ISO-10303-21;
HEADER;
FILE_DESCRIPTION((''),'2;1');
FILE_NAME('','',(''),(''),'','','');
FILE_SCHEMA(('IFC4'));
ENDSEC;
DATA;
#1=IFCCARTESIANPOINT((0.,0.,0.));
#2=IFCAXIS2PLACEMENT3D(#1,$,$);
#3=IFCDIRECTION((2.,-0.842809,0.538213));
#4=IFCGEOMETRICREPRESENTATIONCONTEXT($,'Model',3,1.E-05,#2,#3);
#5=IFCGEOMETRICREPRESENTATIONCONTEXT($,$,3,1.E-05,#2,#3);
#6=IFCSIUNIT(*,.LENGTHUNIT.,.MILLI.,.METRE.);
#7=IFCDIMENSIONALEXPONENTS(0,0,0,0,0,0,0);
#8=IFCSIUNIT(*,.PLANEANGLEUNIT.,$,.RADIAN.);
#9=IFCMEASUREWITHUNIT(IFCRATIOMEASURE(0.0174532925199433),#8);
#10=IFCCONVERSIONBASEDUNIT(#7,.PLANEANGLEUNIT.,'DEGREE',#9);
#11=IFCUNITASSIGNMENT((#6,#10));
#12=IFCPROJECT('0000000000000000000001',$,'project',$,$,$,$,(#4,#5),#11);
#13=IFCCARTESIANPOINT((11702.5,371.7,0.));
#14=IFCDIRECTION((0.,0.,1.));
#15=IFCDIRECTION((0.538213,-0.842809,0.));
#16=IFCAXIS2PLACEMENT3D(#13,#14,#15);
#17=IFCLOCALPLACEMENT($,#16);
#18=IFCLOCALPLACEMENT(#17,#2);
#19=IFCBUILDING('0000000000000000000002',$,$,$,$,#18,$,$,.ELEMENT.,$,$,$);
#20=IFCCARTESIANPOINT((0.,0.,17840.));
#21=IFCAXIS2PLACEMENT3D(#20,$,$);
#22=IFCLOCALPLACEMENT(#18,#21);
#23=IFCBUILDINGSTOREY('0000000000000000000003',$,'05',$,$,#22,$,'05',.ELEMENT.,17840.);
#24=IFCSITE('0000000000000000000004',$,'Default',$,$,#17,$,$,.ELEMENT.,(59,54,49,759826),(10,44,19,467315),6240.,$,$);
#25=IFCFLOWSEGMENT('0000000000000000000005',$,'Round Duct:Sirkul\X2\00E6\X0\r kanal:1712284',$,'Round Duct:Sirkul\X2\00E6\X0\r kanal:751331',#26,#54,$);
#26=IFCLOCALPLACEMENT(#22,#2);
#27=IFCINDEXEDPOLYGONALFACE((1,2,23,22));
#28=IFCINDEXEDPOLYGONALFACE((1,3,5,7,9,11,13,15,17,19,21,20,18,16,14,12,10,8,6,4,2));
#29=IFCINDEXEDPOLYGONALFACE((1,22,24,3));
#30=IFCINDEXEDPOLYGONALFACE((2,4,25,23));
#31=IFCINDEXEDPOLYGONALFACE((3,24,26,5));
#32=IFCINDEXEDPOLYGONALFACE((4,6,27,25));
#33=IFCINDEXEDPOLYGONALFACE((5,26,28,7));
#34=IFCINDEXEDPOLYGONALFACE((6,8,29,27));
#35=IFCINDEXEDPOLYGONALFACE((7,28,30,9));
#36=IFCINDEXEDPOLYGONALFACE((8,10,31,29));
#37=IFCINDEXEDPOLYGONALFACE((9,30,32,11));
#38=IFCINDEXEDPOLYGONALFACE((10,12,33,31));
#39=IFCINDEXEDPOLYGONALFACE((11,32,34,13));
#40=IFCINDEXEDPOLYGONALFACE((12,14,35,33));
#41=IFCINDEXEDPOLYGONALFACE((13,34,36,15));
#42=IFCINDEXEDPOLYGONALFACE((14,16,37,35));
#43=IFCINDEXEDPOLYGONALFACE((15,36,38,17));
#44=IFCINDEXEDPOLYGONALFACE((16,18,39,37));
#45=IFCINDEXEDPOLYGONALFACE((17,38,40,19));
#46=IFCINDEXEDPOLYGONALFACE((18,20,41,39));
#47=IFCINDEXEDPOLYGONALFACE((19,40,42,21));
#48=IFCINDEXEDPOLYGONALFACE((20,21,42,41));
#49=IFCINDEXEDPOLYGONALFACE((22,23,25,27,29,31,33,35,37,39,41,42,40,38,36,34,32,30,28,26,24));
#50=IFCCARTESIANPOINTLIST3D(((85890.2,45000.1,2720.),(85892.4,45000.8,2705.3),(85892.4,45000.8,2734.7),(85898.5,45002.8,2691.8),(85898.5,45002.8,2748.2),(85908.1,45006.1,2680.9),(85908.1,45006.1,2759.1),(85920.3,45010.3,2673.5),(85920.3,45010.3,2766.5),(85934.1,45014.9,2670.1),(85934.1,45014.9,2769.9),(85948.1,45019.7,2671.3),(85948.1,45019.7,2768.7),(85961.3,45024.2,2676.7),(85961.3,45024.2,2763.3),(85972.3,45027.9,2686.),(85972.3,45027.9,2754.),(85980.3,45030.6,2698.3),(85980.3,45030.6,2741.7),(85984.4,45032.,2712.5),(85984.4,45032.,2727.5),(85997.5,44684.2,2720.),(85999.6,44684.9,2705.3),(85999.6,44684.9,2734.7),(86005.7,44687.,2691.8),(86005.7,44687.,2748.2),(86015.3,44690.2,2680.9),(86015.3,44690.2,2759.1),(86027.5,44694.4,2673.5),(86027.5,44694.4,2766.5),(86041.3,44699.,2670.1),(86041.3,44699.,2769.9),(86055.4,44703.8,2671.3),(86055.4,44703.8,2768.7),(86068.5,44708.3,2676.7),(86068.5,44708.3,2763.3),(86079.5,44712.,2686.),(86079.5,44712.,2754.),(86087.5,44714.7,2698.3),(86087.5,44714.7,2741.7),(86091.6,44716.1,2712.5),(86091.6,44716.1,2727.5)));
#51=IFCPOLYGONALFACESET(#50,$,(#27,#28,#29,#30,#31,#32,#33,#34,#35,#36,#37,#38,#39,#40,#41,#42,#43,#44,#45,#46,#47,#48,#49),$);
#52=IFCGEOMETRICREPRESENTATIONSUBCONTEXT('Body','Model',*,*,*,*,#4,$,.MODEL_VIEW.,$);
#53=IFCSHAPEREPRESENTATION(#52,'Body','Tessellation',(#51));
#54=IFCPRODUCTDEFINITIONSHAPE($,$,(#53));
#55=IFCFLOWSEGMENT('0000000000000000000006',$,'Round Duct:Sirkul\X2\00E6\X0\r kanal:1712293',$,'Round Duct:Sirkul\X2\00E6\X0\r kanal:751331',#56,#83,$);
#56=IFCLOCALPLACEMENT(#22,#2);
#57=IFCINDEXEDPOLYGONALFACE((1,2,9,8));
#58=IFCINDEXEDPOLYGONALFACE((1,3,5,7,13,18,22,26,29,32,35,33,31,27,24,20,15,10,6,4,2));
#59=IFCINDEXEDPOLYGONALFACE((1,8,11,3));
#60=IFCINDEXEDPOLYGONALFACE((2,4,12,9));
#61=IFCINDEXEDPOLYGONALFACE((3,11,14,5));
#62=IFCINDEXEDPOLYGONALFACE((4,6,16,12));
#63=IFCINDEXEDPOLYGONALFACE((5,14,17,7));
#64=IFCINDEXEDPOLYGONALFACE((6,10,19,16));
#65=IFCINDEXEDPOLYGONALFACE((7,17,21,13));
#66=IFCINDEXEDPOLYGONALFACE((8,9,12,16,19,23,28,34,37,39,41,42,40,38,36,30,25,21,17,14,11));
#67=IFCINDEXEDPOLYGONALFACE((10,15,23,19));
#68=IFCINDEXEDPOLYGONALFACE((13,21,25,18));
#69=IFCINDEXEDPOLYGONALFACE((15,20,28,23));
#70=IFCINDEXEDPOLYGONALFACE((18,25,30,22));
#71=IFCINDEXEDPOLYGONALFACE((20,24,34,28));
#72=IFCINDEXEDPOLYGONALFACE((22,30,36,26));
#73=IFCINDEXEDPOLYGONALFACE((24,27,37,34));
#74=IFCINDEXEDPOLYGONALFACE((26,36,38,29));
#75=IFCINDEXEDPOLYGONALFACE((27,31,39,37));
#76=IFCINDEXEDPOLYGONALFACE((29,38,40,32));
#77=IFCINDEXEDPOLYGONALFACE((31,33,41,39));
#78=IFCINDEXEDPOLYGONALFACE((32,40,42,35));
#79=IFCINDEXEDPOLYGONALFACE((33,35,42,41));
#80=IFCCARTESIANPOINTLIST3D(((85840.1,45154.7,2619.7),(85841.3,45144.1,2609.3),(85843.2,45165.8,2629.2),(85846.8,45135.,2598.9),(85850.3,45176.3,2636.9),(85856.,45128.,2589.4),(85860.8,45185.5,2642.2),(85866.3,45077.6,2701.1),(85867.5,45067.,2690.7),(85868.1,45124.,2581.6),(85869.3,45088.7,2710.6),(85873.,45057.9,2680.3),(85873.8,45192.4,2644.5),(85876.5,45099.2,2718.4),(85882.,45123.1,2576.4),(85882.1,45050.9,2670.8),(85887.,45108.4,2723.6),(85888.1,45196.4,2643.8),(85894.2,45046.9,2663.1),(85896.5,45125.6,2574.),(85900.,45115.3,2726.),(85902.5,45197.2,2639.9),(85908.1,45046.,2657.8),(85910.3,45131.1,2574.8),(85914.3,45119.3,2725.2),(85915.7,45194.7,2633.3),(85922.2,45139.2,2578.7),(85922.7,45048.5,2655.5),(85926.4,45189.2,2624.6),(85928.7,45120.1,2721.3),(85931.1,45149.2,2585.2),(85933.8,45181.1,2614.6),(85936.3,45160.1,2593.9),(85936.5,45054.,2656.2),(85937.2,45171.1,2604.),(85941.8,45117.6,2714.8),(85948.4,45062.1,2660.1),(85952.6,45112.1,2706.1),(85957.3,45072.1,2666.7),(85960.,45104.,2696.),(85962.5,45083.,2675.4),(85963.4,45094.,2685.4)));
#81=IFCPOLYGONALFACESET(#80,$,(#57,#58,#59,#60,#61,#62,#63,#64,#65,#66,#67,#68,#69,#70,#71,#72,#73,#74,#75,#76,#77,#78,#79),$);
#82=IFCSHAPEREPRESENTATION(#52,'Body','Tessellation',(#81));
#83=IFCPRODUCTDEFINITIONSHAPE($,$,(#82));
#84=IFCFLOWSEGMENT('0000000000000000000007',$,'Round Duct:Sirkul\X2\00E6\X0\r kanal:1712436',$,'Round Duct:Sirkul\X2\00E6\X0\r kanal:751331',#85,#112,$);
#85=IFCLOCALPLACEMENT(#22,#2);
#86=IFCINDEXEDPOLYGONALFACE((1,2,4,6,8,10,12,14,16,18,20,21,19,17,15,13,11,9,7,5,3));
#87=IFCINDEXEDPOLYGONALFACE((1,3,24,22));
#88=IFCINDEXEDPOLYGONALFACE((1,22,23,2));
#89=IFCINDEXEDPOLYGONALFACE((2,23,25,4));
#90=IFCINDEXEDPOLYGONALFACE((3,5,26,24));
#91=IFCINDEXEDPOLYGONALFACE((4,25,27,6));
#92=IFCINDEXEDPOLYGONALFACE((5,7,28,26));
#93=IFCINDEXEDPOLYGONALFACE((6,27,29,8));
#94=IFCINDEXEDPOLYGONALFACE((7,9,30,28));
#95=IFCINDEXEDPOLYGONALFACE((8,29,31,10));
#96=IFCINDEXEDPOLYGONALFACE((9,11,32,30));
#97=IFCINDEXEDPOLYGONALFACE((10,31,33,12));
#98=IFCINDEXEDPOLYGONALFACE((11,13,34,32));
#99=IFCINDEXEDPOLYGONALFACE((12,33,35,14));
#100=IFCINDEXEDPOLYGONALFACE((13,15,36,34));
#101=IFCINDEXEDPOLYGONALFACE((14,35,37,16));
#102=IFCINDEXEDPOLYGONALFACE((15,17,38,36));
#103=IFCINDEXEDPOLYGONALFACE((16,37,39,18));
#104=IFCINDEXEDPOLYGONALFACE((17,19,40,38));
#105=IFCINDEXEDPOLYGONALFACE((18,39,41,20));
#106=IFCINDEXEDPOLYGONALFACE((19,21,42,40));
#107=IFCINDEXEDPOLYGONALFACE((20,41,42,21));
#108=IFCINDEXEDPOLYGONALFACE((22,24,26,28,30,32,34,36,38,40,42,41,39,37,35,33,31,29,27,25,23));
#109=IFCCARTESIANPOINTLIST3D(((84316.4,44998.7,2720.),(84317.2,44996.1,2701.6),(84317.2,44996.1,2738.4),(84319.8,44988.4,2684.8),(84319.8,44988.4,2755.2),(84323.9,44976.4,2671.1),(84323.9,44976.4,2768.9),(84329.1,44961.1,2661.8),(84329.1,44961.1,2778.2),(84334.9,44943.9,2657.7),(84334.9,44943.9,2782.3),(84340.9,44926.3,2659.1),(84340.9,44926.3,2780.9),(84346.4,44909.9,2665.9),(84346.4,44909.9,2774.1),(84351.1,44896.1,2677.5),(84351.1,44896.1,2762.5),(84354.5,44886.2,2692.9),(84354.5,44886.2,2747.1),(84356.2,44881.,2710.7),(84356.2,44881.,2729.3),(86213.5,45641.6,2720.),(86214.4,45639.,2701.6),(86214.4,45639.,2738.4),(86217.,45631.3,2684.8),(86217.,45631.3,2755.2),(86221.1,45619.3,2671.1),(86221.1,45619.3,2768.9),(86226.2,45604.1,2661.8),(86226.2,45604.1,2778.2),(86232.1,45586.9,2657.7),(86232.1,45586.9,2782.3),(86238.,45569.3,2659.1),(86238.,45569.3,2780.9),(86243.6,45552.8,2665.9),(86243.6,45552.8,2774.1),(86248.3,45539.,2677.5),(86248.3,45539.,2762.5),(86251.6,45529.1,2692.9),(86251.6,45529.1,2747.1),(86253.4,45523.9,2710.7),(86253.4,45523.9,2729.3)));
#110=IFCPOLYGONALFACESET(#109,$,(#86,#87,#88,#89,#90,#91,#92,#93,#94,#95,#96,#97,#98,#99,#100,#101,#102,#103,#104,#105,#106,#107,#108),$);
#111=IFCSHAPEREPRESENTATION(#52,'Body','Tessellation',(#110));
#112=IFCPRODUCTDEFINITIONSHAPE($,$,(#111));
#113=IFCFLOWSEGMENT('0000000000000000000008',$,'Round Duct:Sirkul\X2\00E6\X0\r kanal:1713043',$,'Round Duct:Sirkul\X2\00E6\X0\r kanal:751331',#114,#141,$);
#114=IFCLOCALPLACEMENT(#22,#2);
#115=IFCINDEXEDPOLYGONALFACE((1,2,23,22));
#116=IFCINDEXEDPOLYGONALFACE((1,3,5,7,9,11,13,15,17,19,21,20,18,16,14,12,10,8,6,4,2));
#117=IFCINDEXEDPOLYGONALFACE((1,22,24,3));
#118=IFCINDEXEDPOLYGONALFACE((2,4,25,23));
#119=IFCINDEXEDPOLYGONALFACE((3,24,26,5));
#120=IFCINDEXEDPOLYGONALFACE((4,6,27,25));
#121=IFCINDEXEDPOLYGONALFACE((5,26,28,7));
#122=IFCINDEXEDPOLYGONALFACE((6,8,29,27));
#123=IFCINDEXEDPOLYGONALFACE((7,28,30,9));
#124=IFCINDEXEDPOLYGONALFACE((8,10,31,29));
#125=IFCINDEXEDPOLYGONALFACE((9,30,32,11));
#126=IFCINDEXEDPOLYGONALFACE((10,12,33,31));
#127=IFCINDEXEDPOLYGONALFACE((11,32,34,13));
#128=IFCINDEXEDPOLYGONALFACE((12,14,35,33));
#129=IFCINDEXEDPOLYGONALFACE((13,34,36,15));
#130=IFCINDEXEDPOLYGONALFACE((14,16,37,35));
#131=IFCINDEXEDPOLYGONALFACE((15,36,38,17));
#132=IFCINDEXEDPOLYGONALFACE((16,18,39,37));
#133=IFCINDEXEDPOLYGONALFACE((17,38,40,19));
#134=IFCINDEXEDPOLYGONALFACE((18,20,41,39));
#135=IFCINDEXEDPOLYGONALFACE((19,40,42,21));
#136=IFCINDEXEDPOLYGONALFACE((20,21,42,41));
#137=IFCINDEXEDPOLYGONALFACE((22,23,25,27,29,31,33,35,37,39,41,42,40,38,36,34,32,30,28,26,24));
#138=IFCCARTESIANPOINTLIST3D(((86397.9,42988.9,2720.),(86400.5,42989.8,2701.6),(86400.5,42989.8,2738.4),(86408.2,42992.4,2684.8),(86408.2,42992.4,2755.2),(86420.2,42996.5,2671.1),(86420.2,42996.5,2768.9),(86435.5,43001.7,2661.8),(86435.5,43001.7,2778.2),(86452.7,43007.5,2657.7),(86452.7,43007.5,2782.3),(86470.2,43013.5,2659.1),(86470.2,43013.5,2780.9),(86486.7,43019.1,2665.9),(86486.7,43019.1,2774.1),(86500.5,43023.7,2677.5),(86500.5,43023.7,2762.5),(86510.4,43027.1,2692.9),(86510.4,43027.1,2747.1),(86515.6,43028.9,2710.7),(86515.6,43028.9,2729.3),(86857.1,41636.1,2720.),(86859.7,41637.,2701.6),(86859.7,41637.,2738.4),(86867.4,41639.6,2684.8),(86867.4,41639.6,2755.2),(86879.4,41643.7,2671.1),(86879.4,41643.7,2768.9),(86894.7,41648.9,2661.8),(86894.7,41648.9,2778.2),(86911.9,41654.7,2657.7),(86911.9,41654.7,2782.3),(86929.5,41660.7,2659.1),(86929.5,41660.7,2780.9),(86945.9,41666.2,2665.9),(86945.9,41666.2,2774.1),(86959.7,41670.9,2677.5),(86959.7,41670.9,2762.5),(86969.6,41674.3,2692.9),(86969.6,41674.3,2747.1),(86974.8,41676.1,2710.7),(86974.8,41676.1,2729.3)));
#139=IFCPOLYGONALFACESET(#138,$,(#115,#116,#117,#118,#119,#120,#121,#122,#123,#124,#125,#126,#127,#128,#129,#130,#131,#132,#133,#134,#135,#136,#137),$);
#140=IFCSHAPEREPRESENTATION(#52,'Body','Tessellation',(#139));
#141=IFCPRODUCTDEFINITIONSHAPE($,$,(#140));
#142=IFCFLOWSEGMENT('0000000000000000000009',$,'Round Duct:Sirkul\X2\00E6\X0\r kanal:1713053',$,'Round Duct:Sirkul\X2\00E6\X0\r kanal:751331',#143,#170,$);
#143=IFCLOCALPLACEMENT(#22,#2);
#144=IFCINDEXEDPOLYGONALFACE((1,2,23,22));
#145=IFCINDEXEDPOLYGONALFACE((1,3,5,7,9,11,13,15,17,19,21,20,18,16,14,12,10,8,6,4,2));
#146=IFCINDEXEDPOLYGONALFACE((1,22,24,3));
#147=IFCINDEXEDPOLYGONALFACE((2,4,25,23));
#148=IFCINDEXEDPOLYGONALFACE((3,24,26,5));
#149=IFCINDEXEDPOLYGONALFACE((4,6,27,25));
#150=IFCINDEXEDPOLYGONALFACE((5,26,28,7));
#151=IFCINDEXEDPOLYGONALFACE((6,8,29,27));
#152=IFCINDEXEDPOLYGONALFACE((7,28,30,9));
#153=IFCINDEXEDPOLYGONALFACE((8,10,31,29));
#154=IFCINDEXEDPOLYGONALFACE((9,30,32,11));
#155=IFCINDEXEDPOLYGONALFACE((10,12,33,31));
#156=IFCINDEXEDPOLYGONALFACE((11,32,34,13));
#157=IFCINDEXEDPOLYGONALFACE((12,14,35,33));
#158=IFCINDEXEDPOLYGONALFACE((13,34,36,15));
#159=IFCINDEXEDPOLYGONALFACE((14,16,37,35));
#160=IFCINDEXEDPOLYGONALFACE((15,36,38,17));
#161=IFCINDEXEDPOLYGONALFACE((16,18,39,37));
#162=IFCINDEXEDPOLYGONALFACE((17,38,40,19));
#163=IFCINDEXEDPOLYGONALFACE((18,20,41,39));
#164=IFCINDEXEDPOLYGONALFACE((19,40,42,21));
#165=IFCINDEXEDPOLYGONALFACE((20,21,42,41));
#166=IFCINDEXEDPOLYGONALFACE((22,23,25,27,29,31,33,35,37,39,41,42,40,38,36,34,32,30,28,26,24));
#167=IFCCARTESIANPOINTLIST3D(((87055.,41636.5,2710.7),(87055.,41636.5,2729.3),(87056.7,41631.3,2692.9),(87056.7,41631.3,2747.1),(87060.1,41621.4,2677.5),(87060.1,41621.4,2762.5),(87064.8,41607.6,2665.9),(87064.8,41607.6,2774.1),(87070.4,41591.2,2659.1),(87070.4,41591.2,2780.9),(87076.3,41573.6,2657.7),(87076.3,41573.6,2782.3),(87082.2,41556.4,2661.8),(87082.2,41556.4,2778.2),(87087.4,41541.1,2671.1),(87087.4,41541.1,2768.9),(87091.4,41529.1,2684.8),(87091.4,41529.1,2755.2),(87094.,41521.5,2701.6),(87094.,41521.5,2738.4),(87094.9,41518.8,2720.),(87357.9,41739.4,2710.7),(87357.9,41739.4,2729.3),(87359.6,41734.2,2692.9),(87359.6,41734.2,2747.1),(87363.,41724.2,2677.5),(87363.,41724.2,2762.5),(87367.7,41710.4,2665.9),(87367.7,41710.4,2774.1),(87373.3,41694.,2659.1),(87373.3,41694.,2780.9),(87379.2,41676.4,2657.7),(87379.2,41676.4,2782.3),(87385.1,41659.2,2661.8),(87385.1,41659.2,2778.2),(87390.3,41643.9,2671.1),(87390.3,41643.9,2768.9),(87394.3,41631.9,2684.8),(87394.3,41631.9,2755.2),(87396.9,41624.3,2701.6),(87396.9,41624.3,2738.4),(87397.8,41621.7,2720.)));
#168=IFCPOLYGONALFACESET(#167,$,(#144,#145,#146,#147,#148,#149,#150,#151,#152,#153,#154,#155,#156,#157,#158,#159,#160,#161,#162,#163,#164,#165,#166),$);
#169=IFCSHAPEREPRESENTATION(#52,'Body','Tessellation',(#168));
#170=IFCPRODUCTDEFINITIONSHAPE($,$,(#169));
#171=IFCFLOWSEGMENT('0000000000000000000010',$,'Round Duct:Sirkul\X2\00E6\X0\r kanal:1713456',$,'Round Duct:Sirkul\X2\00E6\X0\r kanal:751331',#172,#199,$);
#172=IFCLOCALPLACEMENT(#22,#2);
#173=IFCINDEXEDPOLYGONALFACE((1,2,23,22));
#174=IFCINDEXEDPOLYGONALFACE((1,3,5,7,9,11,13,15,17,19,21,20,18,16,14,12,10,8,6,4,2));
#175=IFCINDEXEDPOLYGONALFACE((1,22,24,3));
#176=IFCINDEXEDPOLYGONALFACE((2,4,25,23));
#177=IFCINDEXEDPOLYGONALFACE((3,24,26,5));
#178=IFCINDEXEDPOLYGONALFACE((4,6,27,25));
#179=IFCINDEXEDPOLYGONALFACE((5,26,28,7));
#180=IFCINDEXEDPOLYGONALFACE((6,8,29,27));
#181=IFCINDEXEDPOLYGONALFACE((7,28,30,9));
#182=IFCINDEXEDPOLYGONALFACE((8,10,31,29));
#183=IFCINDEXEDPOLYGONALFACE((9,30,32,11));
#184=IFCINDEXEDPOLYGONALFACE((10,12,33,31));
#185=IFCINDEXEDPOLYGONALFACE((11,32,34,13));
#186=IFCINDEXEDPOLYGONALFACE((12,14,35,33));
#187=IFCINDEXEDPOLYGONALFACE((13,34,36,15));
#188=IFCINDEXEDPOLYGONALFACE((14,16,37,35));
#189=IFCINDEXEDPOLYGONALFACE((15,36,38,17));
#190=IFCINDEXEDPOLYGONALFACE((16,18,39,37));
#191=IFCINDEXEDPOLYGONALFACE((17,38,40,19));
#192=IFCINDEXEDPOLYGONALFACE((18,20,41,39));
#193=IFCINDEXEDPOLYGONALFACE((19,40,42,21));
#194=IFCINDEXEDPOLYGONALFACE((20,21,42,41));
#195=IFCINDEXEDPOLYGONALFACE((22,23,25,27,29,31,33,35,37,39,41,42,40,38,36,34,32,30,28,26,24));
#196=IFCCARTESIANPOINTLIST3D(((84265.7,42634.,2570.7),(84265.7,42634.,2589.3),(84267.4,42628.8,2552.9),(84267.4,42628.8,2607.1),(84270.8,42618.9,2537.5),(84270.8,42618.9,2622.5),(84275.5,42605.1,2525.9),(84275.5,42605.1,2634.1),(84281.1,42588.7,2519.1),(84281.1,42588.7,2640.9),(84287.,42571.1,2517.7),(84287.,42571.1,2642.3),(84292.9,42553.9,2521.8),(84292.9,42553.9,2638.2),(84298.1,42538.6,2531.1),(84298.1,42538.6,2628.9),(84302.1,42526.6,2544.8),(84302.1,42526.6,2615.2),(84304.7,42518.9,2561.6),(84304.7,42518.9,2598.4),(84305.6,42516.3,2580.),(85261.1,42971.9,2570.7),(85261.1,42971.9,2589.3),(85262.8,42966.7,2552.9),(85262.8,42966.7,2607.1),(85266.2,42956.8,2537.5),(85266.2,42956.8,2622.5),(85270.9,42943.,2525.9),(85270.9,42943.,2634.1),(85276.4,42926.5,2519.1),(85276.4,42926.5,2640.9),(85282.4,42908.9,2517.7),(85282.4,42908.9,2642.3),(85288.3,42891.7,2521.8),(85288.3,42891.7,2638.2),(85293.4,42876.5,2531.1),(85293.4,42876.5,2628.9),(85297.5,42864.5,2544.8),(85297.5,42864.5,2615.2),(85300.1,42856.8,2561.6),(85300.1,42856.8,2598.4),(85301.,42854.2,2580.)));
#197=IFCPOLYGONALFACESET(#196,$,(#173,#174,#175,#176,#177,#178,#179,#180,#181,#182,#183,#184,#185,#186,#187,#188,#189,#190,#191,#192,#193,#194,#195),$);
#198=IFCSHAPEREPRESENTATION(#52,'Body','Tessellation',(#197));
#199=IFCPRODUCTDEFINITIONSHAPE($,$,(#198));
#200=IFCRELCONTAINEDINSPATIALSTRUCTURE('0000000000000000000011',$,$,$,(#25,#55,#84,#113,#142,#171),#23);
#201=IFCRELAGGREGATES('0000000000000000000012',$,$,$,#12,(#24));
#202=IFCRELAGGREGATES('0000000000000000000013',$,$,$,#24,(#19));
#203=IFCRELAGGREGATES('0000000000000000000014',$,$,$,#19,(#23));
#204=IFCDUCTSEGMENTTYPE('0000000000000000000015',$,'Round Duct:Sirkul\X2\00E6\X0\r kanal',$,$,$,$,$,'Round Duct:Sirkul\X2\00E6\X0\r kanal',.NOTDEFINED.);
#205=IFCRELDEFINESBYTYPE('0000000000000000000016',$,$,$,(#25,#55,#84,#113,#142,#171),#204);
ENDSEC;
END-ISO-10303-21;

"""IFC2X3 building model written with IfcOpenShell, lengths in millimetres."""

from ifc_helpers import new_model, entity, si_unit, converted_unit, direction, frame, frame_2d, origin, origin_2d_with_axis, place, context, subcontext, project, spatial, circle, extrude, type_object, element, save


model = new_model("IFC2X3")

# Units and contexts
model_context = context("Model", 3, precision=1e-05, world=origin(), true_north=direction((2.0, -0.842809, 0.538213)))
context_of_model = context(None, 3, precision=1e-05, world=origin(), true_north=direction((2.0, -0.842809, 0.538213)))
body_context = subcontext(model_context, "Body", "Model", "MODEL_VIEW")
ifc_project = project(units=[si_unit("LENGTHUNIT", "METRE", prefix="MILLI"), converted_unit("PLANEANGLEUNIT", "DEGREE", entity("IfcRatioMeasure", 0.0174532925199433), si_unit("PLANEANGLEUNIT", "RADIAN"), dimensions=[0, 0, 0, 0, 0, 0, 0])], contexts=[model_context, context_of_model])

# Site, building, storey
site_placement = place(None, frame((11702.5, 371.7, 0.0), z_axis=(0.0, 0.0, 1.0), x_axis=(0.538213, -0.842809, 0.0)))
site = spatial("IfcSite", under=ifc_project, at=site_placement, Name="Default", CompositionType="ELEMENT", RefLatitude=(59, 54, 49, 759826), RefLongitude=(10, 44, 19, 467315), RefElevation=6240.0)
building_placement = place(site_placement, origin())
building = spatial("IfcBuilding", under=site, at=building_placement, CompositionType="ELEMENT")
storey_placement = place(building_placement, frame((0.0, 0.0, 17840.0)))
storey = spatial("IfcBuildingStorey", under=building, at=storey_placement, Name="05", LongName="05", CompositionType="ELEMENT", Elevation=17840.0)

# Flow segments
duct_segment_type = type_object("IfcDuctSegmentType", Name="Round Duct:Sirkulær kanal", ElementType="Round Duct:Sirkulær kanal", PredefinedType="NOTDEFINED")
flow_segment_1_placement = place(storey_placement, origin())
element("IfcFlowSegment", 1, at=flow_segment_1_placement, inside=storey, type_object=duct_segment_type, Name="Round Duct:Sirkulær kanal:1712284", ObjectType="Round Duct:Sirkulær kanal:751331", context=body_context, shape_type="SweptSolid", body=[
    extrude(circle(Radius=50.0, at=origin_2d_with_axis()), frame((85937.6, 45016.1, 2720.0), z_axis=(0.321439, -0.94693, 0.0), x_axis=(-0.94693, -0.321439, 0.0)), (0.0, 0.0, 1.0), 333.6),
])
flow_segment_2_placement = place(storey_placement, origin())
element("IfcFlowSegment", 2, at=flow_segment_2_placement, inside=storey, type_object=duct_segment_type, Name="Round Duct:Sirkulær kanal:1712293", ObjectType="Round Duct:Sirkulær kanal:751331", context=body_context, shape_type="SweptSolid", body=[
    extrude(circle(Radius=50.0, at=frame_2d((0.0, 0.0), x_axis=(1.0, 0.0))), frame((85888.7, 45160.2, 2609.3), z_axis=(0.227292, -0.669581, 0.707107), x_axis=(-0.94693, -0.321439, 0.0)), (0.0, 0.0, 1.0), 115.1),
])
flow_segment_3_placement = place(storey_placement, origin())
element("IfcFlowSegment", 3, at=flow_segment_3_placement, inside=storey, type_object=duct_segment_type, Name="Round Duct:Sirkulær kanal:1712436", ObjectType="Round Duct:Sirkulær kanal:751331", context=body_context, shape_type="SweptSolid", body=[
    extrude(circle(Radius=62.5, at=origin_2d_with_axis()), frame((84336.4, 44939.5, 2720.0), z_axis=(0.947093, 0.320961, 0.0), x_axis=(-0.320961, 0.947093, 0.0)), (0.0, 0.0, 1.0), 2003.1),
])
flow_segment_4_placement = place(storey_placement, origin())
element("IfcFlowSegment", 4, at=flow_segment_4_placement, inside=storey, type_object=duct_segment_type, Name="Round Duct:Sirkulær kanal:1713043", ObjectType="Round Duct:Sirkulær kanal:751331", context=body_context, shape_type="SweptSolid", body=[
    extrude(circle(Radius=62.5, at=origin_2d_with_axis()), frame((86457.1, 43009.0, 2720.0), z_axis=(0.321439, -0.94693, 0.0), x_axis=(-0.94693, -0.321439, 0.0)), (0.0, 0.0, 1.0), 1428.6),
])
flow_segment_5_placement = place(storey_placement, origin())
element("IfcFlowSegment", 5, at=flow_segment_5_placement, inside=storey, type_object=duct_segment_type, Name="Round Duct:Sirkulær kanal:1713053", ObjectType="Round Duct:Sirkulær kanal:751331", context=body_context, shape_type="SweptSolid", body=[
    extrude(circle(Radius=62.5, at=origin_2d_with_axis()), frame((87074.8, 41578.0, 2720.0), z_axis=(0.94693, 0.321439, 0.0), x_axis=(0.321439, -0.94693, 0.0)), (0.0, 0.0, 1.0), 319.9),
])
flow_segment_6_placement = place(storey_placement, origin())
element("IfcFlowSegment", 6, at=flow_segment_6_placement, inside=storey, type_object=duct_segment_type, Name="Round Duct:Sirkulær kanal:1713456", ObjectType="Round Duct:Sirkulær kanal:751331", context=body_context, shape_type="SweptSolid", body=[
    extrude(circle(Radius=62.5, at=origin_2d_with_axis()), frame((84285.5, 42575.5, 2580.0), z_axis=(0.94693, 0.321439, 0.0), x_axis=(0.321439, -0.94693, 0.0)), (0.0, 0.0, 1.0), 1051.2),
])

save(model, "model.ifc")
